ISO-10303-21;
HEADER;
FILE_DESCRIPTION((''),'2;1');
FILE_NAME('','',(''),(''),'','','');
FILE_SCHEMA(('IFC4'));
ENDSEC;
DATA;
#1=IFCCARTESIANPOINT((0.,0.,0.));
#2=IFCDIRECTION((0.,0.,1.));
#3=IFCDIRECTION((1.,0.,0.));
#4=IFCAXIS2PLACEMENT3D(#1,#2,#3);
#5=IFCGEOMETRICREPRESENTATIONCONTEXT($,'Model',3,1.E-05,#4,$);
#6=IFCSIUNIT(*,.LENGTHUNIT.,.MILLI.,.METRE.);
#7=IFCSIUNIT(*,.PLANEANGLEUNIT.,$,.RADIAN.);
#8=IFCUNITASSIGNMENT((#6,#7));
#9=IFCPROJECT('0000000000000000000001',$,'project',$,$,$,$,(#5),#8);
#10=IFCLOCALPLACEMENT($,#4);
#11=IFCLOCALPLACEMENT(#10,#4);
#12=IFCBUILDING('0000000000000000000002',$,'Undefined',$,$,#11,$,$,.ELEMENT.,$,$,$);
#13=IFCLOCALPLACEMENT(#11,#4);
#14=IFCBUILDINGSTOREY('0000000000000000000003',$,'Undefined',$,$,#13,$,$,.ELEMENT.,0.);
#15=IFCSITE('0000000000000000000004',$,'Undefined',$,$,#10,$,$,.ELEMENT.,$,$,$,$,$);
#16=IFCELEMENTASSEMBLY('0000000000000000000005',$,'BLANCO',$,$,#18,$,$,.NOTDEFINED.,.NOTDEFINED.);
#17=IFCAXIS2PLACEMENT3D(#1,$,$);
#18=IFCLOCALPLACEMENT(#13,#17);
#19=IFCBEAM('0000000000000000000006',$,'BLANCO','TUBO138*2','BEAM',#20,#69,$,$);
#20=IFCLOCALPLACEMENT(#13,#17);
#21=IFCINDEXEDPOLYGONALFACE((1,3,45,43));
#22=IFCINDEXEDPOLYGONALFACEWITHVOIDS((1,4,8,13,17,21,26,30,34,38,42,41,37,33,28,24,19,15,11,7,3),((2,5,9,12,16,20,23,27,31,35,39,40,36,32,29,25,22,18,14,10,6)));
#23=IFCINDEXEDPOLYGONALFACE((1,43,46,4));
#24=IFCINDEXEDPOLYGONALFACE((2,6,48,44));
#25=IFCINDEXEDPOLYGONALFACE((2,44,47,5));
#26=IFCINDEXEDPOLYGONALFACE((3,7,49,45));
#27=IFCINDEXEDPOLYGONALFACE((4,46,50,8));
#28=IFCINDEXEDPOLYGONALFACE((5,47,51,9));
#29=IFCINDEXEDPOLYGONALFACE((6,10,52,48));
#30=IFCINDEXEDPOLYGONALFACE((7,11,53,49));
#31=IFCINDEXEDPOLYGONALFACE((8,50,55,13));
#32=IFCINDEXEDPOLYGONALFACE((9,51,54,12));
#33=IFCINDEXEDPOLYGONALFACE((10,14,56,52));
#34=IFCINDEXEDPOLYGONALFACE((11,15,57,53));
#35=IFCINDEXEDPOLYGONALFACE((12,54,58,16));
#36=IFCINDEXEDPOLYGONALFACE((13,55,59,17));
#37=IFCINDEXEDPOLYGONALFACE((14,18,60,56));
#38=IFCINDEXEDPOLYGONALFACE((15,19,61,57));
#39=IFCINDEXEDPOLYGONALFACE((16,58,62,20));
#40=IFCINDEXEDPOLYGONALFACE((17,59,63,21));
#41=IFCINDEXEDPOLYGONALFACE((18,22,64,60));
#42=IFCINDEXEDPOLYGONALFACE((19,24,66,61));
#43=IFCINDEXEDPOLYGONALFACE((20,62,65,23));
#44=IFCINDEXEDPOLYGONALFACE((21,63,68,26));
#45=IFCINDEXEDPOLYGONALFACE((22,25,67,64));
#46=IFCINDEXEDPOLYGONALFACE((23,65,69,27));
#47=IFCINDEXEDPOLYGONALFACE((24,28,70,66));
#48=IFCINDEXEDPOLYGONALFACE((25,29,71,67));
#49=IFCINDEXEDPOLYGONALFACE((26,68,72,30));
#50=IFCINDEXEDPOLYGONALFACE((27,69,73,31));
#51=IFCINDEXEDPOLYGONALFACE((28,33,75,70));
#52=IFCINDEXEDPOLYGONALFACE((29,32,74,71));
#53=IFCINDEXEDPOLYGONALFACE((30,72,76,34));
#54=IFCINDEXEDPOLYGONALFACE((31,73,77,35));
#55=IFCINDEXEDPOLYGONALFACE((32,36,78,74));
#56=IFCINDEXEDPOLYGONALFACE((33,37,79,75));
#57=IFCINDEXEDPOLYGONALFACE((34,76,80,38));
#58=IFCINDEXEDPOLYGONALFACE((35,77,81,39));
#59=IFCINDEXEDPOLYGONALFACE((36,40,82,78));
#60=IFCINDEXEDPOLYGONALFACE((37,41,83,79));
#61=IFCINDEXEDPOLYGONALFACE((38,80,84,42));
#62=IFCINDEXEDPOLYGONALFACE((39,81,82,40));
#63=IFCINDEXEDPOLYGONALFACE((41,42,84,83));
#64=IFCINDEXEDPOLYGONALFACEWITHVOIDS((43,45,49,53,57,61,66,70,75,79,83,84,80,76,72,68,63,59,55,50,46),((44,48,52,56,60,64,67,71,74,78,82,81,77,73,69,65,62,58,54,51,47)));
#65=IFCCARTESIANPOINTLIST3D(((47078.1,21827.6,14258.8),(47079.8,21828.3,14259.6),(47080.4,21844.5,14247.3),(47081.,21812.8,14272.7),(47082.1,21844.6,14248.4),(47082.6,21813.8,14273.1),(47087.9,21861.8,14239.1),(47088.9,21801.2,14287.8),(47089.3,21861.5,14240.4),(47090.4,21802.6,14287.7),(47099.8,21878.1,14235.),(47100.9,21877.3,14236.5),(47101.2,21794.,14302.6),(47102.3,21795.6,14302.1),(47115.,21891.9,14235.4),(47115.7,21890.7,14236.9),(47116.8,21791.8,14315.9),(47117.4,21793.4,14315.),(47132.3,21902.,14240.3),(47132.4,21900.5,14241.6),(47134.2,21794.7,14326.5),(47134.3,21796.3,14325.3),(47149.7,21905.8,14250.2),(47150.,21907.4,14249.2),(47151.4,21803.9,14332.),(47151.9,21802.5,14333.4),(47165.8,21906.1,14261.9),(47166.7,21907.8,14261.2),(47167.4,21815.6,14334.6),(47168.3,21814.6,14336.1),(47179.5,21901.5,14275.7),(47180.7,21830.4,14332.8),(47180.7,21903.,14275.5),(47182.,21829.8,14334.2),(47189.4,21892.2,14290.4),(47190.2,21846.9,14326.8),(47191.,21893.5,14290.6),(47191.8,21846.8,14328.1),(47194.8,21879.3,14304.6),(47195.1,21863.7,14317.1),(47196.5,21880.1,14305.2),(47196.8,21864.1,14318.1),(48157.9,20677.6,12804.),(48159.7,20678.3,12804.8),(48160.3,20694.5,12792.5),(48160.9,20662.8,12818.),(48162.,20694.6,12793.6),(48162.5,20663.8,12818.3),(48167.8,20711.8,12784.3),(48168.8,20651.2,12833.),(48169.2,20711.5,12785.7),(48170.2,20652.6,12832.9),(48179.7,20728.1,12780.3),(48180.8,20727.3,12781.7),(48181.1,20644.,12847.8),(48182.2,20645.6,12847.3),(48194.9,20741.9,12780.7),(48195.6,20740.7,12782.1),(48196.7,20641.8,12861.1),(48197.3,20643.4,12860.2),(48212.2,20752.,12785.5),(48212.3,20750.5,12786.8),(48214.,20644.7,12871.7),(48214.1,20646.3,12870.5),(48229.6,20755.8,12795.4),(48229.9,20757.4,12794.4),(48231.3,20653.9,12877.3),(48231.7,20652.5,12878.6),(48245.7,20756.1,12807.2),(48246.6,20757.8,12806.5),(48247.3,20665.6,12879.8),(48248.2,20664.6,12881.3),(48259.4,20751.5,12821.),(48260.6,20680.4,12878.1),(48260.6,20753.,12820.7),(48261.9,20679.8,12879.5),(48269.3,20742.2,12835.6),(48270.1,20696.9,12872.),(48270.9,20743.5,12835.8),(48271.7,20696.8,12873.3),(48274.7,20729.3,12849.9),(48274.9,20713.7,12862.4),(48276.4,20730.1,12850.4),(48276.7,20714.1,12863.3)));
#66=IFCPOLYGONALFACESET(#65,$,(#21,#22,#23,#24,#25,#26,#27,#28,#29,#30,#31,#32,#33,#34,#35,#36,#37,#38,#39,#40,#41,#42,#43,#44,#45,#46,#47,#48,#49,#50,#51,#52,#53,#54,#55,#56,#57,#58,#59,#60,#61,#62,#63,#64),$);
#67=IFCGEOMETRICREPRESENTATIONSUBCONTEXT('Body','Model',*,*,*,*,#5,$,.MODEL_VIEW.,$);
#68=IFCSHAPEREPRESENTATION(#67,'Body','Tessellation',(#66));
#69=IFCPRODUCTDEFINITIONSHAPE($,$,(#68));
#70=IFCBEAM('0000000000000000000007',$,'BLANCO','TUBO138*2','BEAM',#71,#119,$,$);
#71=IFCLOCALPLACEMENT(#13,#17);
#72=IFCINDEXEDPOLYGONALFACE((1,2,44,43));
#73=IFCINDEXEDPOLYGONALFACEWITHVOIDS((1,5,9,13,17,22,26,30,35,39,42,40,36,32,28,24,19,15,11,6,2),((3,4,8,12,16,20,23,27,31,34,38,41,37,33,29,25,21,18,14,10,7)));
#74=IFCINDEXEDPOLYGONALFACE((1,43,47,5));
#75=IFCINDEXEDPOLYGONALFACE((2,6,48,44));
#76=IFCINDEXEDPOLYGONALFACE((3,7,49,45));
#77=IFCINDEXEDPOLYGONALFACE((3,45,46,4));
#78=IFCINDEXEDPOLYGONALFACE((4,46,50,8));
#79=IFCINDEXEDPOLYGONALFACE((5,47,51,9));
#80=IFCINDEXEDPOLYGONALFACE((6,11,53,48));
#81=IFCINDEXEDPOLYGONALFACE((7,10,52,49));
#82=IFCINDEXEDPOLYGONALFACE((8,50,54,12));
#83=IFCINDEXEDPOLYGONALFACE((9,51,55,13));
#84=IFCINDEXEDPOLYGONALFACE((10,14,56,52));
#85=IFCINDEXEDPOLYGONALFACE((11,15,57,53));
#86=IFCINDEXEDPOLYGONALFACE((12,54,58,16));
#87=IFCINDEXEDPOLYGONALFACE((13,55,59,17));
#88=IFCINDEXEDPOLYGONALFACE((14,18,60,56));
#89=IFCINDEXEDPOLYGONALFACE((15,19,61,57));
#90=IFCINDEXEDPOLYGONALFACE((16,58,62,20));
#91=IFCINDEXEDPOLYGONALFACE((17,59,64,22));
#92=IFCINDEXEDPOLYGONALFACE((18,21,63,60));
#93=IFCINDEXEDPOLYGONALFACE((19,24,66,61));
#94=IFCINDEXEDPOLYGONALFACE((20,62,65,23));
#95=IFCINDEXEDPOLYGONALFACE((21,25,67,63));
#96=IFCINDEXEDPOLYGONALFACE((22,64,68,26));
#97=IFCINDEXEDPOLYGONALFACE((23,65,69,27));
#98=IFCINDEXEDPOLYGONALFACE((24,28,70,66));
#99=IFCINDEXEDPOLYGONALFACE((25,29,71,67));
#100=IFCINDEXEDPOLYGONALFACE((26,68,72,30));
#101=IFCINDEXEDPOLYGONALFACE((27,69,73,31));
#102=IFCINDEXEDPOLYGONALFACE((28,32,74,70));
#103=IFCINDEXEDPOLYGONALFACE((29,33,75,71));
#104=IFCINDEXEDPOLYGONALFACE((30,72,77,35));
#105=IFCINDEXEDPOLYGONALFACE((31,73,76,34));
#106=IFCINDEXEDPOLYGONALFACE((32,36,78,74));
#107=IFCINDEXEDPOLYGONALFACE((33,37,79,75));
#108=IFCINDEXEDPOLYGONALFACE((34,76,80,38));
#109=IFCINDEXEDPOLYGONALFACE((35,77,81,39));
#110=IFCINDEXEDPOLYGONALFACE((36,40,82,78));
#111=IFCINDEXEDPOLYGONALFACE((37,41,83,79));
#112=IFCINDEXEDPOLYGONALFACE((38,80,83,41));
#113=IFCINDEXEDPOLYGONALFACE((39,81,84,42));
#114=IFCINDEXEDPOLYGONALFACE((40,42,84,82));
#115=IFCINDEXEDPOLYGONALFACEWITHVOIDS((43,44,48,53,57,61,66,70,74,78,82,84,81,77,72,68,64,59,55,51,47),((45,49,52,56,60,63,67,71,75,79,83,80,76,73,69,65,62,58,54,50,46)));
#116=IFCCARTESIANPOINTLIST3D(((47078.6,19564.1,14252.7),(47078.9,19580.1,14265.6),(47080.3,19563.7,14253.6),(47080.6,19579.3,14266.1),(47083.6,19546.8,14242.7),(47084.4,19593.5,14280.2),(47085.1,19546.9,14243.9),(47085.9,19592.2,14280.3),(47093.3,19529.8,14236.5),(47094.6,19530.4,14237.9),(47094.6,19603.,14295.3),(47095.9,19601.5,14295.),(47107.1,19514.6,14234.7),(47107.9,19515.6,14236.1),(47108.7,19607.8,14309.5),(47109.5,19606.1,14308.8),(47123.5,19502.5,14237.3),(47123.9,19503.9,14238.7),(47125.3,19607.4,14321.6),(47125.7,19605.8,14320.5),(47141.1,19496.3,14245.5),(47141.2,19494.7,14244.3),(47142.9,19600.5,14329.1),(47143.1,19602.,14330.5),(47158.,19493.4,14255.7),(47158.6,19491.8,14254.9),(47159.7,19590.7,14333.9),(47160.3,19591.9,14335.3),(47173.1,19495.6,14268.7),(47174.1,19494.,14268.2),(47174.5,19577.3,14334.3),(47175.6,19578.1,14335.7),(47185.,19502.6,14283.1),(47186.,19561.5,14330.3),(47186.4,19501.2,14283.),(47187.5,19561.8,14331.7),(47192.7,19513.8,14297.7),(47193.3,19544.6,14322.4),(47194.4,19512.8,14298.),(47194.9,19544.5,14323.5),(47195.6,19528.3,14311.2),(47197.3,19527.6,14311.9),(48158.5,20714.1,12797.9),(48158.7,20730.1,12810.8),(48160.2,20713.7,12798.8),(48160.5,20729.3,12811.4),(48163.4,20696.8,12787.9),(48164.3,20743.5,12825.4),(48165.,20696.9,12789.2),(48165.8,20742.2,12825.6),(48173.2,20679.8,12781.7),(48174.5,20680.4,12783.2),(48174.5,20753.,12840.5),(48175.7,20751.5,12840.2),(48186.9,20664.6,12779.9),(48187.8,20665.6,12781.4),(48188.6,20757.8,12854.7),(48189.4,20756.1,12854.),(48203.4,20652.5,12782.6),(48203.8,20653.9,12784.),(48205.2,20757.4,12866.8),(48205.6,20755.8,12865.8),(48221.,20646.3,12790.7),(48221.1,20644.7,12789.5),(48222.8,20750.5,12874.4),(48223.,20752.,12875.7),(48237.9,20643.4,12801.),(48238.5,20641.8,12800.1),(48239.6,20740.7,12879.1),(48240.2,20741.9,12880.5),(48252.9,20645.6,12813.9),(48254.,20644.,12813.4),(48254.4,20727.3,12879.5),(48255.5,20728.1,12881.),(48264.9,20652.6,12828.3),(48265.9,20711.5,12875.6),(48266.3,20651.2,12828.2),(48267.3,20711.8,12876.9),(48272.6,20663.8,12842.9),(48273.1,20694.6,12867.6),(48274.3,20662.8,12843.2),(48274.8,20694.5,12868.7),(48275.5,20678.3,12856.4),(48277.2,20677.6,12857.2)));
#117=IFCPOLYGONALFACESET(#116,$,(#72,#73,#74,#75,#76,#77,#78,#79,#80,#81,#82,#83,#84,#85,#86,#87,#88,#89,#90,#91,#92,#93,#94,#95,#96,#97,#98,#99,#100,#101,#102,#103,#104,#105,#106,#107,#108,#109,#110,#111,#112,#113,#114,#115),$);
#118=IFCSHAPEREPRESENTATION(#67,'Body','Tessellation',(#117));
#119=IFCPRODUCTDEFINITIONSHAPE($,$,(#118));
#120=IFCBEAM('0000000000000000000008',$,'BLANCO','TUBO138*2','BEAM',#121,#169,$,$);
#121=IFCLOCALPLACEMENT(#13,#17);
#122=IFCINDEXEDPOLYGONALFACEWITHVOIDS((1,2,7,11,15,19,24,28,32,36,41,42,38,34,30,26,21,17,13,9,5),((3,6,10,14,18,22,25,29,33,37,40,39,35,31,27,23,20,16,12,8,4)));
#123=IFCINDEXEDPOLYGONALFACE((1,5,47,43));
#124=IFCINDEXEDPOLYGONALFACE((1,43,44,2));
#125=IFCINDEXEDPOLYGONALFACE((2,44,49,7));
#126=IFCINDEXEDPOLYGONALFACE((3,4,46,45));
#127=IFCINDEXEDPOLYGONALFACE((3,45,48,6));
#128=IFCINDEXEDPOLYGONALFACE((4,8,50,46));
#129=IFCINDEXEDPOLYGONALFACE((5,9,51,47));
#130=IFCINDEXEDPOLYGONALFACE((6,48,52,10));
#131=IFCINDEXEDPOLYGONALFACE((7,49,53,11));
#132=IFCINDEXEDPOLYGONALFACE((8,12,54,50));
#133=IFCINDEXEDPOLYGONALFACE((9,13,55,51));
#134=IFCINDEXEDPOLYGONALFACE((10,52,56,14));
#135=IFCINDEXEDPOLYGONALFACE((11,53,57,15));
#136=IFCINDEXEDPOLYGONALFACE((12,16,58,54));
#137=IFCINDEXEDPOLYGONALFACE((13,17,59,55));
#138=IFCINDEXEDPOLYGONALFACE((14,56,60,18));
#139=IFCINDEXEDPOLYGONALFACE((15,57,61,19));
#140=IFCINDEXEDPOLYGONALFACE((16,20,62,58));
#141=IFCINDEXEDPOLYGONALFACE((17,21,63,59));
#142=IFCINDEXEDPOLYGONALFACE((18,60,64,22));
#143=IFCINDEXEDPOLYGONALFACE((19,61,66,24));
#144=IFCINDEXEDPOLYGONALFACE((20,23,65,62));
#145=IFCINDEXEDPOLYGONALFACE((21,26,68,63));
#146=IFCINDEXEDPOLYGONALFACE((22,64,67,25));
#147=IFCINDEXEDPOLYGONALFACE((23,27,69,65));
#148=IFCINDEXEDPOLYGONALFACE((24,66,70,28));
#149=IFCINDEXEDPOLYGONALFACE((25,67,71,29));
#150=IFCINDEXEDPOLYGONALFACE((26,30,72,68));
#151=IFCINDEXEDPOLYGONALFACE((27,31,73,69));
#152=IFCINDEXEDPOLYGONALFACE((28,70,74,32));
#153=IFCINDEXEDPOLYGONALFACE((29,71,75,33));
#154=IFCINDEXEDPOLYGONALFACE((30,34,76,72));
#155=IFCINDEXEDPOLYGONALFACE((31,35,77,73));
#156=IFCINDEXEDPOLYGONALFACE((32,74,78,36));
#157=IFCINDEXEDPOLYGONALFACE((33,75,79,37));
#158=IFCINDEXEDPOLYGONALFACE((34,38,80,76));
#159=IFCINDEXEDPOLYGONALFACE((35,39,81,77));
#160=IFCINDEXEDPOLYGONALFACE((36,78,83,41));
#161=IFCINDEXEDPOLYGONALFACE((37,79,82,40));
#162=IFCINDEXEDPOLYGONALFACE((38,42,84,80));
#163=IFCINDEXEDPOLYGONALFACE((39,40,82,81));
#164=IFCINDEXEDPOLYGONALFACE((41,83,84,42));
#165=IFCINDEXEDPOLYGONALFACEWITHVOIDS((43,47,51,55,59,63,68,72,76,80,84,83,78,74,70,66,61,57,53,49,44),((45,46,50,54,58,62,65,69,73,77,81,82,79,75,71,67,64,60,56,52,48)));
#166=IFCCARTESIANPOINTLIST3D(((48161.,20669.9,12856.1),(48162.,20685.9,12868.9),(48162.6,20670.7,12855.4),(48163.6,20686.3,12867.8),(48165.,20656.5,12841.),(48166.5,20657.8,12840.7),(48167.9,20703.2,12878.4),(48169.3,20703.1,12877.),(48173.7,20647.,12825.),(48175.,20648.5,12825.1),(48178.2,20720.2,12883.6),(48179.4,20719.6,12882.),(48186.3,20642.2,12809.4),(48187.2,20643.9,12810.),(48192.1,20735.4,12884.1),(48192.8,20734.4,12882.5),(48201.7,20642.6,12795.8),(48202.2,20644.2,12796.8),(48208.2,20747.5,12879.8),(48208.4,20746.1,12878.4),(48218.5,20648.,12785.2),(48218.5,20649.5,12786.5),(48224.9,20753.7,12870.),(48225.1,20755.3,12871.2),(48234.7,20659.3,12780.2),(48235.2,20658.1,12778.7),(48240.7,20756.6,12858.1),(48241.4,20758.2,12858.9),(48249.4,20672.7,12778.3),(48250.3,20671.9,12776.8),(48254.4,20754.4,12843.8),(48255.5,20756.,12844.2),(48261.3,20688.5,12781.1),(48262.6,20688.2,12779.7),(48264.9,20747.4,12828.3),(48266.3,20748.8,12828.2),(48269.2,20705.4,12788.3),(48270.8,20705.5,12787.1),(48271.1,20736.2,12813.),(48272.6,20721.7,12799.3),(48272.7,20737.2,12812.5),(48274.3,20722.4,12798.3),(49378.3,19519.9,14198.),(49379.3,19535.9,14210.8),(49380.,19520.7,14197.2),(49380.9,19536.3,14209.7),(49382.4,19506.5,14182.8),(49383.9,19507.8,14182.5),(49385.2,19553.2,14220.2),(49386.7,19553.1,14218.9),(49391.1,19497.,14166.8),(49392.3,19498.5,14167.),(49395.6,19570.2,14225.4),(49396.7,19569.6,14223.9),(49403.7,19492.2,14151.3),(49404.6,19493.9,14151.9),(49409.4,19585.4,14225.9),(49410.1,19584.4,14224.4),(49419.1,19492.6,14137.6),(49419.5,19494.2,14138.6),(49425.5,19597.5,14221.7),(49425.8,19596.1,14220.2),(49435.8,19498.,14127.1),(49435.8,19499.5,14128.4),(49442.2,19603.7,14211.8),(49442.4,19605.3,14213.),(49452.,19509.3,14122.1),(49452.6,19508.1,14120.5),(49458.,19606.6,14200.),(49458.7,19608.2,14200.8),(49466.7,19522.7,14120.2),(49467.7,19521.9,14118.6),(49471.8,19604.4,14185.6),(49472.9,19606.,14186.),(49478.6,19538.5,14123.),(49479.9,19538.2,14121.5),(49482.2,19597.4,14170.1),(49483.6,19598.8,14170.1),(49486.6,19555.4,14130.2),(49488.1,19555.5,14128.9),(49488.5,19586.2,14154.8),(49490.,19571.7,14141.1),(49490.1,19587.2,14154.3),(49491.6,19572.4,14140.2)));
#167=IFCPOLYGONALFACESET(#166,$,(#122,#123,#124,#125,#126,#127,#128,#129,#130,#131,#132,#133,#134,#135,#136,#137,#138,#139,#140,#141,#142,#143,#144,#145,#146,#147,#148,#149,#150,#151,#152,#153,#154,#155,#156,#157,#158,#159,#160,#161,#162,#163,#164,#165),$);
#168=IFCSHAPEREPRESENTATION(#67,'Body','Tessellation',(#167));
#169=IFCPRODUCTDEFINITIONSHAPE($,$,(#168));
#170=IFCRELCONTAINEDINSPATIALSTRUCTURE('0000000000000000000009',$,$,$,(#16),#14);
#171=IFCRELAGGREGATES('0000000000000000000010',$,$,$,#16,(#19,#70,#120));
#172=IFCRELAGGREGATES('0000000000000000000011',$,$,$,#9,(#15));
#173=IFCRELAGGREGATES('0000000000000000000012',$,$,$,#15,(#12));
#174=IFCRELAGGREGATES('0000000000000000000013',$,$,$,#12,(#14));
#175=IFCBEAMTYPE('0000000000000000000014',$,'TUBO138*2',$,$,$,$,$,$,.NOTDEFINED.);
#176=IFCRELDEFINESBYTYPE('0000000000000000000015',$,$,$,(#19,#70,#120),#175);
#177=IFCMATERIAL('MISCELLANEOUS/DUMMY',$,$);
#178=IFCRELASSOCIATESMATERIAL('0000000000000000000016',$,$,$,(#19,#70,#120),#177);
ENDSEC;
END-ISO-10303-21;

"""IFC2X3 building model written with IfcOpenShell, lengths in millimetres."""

from ifc_helpers import new_model, si_unit, frame, origin_with_axes, origin_2d_with_axis, place, context, subcontext, project, spatial, hollow_circle, extrude, material, type_object, element, aggregate, save


model = new_model("IFC2X3")

# Units and contexts
model_context = context("Model", 3, precision=1e-05, world=origin_with_axes())
body_context = subcontext(model_context, "Body", "Model", "MODEL_VIEW")
ifc_project = project(units=[si_unit("LENGTHUNIT", "METRE", prefix="MILLI"), si_unit("PLANEANGLEUNIT", "RADIAN")], contexts=[model_context])

# Site, building, storey
site_placement = place(None, origin_with_axes())
site = spatial("IfcSite", under=ifc_project, at=site_placement, Name="Undefined", CompositionType="ELEMENT")
building_placement = place(site_placement, origin_with_axes())
building = spatial("IfcBuilding", under=site, at=building_placement, Name="Undefined", CompositionType="ELEMENT")
storey_placement = place(building_placement, origin_with_axes())
storey = spatial("IfcBuildingStorey", under=building, at=storey_placement, Name="Undefined", CompositionType="ELEMENT", Elevation=0.0)

# Element assembly, beams
assembly_placement = place(storey_placement, origin_with_axes())
assembly = element("IfcElementAssembly", 1, at=assembly_placement, inside=storey, Name="BLANCO", AssemblyPlace="NOTDEFINED", PredefinedType="NOTDEFINED")
ifc_material = material(Name="MISCELLANEOUS/DUMMY")
beam_type = type_object("IfcBeamType", Name="TUBO138*2", PredefinedType="NOTDEFINED")
beam_1_placement = place(assembly_placement, frame((48217.6, 20700.0, 12830.6), z_axis=(-0.497966, 0.461316, -0.734314), x_axis=(-0.503224, 0.535899, 0.677922)))
beam_1 = element("IfcBeam", 2, at=beam_1_placement, type_object=beam_type, material=ifc_material, Name="BLANCO", Description="TUBO138*2", ObjectType="BEAM", context=body_context, shape_type="SweptSolid", body=[
    extrude(hollow_circle(Radius=69.0, WallThickness=2.0, at=origin_2d_with_axis()), frame((2145.9, 0.0, 0.0), z_axis=(-1.0, 0.0, 0.0), x_axis=(0.0, -1.0, 0.0)), (0.0, 0.0, 1.0), 2145.9),
])
beam_2_placement = place(assembly_placement, frame((48217.6, 20700.0, 12830.6), z_axis=(-0.497966, -0.461316, -0.734314), x_axis=(-0.503224, -0.535899, 0.677922)))
beam_2 = element("IfcBeam", 3, at=beam_2_placement, type_object=beam_type, material=ifc_material, Name="BLANCO", Description="TUBO138*2", ObjectType="BEAM", context=body_context, shape_type="SweptSolid", body=[
    extrude(hollow_circle(Radius=69.0, WallThickness=2.0, at=origin_2d_with_axis()), frame((2145.9, 0.0, 0.0), z_axis=(-1.0, 0.0, 0.0), x_axis=(0.0, -1.0, 0.0)), (0.0, 0.0, 1.0), 2145.9),
])
beam_3_placement = place(assembly_placement, frame((48217.6, 20700.0, 12830.6), z_axis=(0.423552, -0.461316, -0.77961), x_axis=(0.567282, -0.535899, 0.625303)))
beam_3 = element("IfcBeam", 4, at=beam_3_placement, type_object=beam_type, material=ifc_material, Name="BLANCO", Description="TUBO138*2", ObjectType="BEAM", context=body_context, shape_type="SweptSolid", body=[
    extrude(hollow_circle(Radius=69.0, WallThickness=2.0, at=origin_2d_with_axis()), frame((2145.9, 0.0, 0.0), z_axis=(-1.0, 0.0, 0.0), x_axis=(0.0, -1.0, 0.0)), (0.0, 0.0, 1.0), 2145.9),
])
aggregate(assembly, [beam_1, beam_2, beam_3])

save(model, "model.ifc")
